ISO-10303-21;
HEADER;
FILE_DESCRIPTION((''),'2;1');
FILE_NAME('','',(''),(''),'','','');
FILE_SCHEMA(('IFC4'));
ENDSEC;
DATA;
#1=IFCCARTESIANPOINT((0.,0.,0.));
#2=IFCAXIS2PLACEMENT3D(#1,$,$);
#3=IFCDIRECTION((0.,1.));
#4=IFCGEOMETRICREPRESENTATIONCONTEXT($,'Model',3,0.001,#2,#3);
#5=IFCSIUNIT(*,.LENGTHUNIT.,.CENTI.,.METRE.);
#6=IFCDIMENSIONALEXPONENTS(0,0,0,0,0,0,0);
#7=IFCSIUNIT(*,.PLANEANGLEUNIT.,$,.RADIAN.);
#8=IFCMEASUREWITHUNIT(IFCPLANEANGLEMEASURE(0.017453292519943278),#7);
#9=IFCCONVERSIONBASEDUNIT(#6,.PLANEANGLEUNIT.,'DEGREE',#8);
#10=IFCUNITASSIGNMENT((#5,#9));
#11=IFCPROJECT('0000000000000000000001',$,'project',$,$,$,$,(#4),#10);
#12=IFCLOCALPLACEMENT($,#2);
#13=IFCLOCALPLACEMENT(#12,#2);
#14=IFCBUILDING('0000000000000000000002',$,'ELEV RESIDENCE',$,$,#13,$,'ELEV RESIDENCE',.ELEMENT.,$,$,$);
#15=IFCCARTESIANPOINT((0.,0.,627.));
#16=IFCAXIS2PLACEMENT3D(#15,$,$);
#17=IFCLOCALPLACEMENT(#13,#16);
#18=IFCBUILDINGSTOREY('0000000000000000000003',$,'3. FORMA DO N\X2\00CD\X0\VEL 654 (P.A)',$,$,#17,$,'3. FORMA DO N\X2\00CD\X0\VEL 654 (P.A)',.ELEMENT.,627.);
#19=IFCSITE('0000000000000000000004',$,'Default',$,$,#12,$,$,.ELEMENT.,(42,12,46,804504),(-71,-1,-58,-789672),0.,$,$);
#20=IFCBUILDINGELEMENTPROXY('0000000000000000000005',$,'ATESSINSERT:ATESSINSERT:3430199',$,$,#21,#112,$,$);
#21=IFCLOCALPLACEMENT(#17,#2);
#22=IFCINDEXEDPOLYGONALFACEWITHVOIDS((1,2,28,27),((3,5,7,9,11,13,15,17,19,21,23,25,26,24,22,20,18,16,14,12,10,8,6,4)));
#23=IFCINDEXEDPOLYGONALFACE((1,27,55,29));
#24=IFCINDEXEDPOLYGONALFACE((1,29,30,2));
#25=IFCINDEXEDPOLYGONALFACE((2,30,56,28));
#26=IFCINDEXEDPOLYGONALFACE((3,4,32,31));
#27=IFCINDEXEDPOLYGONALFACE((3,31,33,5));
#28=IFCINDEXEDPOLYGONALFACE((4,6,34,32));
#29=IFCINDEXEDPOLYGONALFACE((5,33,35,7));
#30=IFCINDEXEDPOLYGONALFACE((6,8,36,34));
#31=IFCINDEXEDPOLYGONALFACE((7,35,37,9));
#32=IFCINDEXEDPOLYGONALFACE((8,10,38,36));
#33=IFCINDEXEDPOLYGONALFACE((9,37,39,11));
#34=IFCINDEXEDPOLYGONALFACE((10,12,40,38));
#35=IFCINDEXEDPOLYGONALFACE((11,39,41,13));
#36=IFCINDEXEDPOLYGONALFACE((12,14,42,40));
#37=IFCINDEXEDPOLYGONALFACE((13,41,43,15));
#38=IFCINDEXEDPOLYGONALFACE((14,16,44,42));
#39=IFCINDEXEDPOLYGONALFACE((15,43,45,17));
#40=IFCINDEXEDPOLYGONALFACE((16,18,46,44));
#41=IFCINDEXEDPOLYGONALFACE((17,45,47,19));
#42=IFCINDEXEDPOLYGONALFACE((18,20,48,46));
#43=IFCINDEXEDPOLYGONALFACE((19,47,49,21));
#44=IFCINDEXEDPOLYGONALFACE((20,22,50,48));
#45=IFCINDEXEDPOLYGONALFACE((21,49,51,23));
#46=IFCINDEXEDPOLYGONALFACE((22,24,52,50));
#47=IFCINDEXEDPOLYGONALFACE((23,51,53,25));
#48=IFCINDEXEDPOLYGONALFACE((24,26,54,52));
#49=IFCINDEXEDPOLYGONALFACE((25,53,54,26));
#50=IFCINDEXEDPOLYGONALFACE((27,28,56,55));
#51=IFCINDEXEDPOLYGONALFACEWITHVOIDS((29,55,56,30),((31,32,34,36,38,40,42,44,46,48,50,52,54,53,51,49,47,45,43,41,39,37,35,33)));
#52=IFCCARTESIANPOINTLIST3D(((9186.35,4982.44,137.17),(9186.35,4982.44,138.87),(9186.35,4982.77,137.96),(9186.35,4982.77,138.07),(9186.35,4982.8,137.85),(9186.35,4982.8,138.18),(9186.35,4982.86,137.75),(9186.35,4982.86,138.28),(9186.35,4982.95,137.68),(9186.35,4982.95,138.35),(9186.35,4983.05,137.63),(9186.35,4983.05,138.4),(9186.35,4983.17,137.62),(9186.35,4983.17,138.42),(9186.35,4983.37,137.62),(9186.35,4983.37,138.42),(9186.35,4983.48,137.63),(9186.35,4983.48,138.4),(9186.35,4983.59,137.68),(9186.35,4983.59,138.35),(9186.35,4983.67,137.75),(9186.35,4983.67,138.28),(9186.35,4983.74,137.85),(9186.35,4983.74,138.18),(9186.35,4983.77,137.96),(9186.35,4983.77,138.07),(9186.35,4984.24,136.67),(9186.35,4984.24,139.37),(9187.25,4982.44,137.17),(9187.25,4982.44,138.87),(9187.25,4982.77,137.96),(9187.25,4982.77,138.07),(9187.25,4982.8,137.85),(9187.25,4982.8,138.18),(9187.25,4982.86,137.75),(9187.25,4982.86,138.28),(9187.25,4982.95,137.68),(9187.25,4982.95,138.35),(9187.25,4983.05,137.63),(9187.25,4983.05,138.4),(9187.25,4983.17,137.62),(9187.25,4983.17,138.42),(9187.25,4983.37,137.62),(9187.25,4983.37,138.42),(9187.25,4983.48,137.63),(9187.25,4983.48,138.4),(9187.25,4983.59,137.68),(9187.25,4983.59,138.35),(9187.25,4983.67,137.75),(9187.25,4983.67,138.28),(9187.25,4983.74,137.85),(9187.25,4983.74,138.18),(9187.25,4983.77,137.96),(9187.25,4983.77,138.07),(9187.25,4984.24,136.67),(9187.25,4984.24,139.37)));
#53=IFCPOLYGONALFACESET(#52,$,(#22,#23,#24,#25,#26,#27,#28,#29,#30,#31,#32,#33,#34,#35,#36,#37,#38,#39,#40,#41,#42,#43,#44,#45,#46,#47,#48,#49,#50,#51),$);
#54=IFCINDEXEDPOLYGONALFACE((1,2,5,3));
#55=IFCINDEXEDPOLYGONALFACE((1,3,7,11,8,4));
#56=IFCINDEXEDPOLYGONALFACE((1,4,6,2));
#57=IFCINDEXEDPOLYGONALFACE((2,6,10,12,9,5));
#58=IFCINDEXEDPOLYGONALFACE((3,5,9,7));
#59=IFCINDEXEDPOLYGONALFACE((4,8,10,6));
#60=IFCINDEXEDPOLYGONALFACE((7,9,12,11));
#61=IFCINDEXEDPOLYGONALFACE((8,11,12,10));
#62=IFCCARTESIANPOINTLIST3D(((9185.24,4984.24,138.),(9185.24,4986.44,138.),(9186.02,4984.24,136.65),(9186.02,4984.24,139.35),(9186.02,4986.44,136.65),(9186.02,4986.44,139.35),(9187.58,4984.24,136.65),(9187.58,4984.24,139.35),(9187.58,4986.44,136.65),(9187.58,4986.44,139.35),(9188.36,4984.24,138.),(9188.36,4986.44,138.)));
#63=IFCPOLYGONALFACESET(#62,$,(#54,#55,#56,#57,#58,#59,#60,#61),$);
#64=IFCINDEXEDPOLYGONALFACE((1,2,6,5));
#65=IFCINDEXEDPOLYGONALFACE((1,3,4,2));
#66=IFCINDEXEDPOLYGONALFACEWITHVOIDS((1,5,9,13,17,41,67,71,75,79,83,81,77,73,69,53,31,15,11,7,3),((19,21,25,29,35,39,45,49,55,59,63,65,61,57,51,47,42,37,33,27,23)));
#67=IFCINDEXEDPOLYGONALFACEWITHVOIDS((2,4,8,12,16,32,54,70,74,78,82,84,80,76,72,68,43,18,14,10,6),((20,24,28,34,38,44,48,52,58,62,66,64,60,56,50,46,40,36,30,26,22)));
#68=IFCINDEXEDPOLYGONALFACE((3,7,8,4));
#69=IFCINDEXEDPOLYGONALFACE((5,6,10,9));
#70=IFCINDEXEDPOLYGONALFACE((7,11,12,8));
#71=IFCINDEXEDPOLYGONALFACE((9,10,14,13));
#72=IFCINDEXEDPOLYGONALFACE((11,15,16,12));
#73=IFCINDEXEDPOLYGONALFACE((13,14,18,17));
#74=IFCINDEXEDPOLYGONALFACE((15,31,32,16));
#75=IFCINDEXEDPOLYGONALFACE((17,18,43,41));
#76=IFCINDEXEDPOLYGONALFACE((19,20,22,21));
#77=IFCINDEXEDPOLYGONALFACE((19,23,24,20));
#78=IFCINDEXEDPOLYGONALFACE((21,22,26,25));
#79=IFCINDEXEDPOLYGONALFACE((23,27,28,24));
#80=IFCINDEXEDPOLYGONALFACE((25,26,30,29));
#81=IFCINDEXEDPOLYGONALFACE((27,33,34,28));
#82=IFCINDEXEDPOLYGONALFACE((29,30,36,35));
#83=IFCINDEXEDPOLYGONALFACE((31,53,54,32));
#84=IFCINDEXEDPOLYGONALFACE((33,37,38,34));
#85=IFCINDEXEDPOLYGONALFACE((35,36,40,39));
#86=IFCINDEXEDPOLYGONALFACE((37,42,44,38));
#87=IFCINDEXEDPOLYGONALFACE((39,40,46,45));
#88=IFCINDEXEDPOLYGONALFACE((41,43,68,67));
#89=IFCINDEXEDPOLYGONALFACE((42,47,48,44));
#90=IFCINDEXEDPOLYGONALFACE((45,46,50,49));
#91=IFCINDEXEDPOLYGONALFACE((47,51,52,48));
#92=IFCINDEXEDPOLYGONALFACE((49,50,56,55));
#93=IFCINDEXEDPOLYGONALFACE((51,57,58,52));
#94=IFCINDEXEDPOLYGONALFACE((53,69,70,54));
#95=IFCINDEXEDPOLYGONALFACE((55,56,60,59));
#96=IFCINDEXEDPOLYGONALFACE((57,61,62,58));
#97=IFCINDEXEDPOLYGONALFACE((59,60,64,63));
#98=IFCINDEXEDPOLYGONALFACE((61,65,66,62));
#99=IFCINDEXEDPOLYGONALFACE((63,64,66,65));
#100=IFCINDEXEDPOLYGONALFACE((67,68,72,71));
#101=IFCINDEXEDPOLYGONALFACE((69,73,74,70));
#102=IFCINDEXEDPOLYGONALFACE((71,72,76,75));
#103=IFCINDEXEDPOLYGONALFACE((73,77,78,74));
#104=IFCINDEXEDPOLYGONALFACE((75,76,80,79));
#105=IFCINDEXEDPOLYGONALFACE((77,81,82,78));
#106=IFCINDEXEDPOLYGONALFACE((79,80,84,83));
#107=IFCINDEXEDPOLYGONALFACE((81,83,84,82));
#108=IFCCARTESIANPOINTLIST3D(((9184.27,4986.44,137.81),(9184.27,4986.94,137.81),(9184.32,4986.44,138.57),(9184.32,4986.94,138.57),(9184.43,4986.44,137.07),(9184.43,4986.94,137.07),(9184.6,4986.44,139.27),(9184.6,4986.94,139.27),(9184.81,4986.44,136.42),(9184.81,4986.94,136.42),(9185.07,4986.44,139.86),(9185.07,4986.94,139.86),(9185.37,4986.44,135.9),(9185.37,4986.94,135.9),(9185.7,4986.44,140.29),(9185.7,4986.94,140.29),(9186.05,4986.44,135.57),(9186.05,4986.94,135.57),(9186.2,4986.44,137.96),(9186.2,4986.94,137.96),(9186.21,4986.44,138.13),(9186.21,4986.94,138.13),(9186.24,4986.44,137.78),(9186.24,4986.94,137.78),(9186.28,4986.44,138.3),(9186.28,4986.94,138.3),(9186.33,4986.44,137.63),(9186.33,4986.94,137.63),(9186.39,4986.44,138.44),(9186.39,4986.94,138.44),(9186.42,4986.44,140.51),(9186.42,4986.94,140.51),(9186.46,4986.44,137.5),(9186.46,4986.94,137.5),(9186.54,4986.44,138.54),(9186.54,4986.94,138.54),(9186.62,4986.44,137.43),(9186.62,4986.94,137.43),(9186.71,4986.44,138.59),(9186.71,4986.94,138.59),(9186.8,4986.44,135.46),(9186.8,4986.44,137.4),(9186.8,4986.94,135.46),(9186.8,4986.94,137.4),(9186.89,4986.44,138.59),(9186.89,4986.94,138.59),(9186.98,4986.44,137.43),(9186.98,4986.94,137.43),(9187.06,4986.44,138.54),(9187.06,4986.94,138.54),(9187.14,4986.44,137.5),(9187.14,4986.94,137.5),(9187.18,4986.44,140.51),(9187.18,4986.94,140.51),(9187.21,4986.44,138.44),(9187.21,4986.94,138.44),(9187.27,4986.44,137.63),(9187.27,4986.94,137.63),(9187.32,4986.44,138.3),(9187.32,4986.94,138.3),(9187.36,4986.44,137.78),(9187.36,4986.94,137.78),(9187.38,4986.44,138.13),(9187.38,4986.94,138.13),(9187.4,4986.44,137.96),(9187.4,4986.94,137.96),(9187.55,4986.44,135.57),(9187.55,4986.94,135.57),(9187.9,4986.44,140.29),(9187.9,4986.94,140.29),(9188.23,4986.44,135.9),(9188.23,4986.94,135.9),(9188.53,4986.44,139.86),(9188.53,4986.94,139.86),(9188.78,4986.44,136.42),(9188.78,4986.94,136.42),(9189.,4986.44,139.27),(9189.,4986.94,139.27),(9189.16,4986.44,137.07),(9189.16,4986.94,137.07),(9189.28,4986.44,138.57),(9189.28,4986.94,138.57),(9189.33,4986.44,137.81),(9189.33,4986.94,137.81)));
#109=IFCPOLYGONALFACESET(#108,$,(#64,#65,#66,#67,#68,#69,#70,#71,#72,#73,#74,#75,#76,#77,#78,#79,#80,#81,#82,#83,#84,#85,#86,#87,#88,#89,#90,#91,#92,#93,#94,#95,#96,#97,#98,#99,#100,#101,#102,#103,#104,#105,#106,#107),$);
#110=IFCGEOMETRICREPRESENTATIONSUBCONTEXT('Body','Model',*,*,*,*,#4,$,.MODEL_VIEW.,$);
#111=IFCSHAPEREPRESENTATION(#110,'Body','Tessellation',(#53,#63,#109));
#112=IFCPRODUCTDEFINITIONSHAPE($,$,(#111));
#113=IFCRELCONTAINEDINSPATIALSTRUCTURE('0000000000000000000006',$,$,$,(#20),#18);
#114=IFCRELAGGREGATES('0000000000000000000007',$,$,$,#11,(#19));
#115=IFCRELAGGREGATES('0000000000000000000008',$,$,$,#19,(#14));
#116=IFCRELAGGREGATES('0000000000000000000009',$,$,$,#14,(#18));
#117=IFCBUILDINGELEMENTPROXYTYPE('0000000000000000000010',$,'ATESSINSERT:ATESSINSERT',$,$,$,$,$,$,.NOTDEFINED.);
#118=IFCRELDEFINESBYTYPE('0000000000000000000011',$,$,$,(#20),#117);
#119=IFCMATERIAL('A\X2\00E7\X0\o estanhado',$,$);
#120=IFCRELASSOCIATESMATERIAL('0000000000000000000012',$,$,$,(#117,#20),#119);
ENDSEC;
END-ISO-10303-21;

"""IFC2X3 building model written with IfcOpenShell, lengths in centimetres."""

from ifc_helpers import new_model, entity, si_unit, converted_unit, direction, frame, frame_2d, origin, place, context, subcontext, project, spatial, polyline, circle_curve, parameter, trimmed, segment, composite_curve, hollow_circle, outline, extrude, source, transform, mapped, material, type_object, type_shapes, element, save


model = new_model("IFC2X3")

# Units and contexts
model_context = context("Model", 3, precision=0.001, world=origin(), true_north=direction((0.0, 1.0)))
body_context = subcontext(model_context, "Body", "Model", "MODEL_VIEW")
ifc_project = project(units=[si_unit("LENGTHUNIT", "METRE", prefix="CENTI"), converted_unit("PLANEANGLEUNIT", "DEGREE", entity("IfcPlaneAngleMeasure", 0.017453292519943278), si_unit("PLANEANGLEUNIT", "RADIAN"), dimensions=[0, 0, 0, 0, 0, 0, 0])], contexts=[model_context])

# Site, building, storey
site_placement = place(None, origin())
site = spatial("IfcSite", under=ifc_project, at=site_placement, Name="Default", CompositionType="ELEMENT", RefLatitude=(42, 12, 46, 804504), RefLongitude=(-71, -1, -58, -789672), RefElevation=0.0)
building_placement = place(site_placement, origin())
building = spatial("IfcBuilding", under=site, at=building_placement, Name="ELEV RESIDENCE", LongName="ELEV RESIDENCE", CompositionType="ELEMENT")
storey_placement = place(building_placement, frame((0.0, 0.0, 627.0)))
storey = spatial("IfcBuildingStorey", under=building, at=storey_placement, Name="3. FORMA DO NÍVEL 654 (P.A)", LongName="3. FORMA DO NÍVEL 654 (P.A)", CompositionType="ELEMENT", Elevation=627.0)

# Building element proxy
ifc_material_1 = material(Name="Aço estanhado")
building_element_proxy_type_1 = type_object("IfcBuildingElementProxyType", Name="ATESSINSERT:ATESSINSERT", PredefinedType="NOTDEFINED", material=ifc_material_1)
shared_shape_1 = source(origin(), body_context, "Body", "SweptSolid", [
    extrude(outline(polyline([(-1.35, -0.9), (1.35, -0.9), (0.85, 0.9), (-0.85, 0.9), (-1.35, -0.9)]), holes=[composite_curve([segment(trimmed(circle_curve(frame_2d((0.0, 0.17), x_axis=(1.0, 0.0)), 0.4), [parameter(0.0)], [parameter(180.0)], True, "PARAMETER"), False, "CONTINUOUS"), segment(polyline([(0.4, 0.17), (0.4, -0.03)]), True, "CONTINUOUS"), segment(trimmed(circle_curve(frame_2d((0.0, -0.03), x_axis=(1.0, 0.0)), 0.4), [parameter(180.0)], [parameter(0.0)], True, "PARAMETER"), False, "CONTINUOUS"), segment(polyline([(-0.4, -0.03), (-0.4, 0.17)]), True, "CONTINUOUS")], self_intersect=False)]), frame((-1.4, -0.45, 30.02), z_axis=(0.0, 1.0, 0.0), x_axis=(0.0, 0.0, 1.0)), (0.0, 0.0, 1.0), 0.9),
    extrude(outline(polyline([(-0.78, -1.35), (0.78, -1.35), (1.56, 0.0), (0.78, 1.35), (-0.78, 1.35), (-1.56, 0.0), (-0.78, -1.35)])), frame((-4.5, 0.0, 30.0), z_axis=(1.0, 0.0, 0.0), x_axis=(0.0, 1.0, 0.0)), (0.0, 0.0, 1.0), 2.2),
    extrude(hollow_circle(Radius=2.54, WallThickness=1.94, at=frame_2d((0.0, 0.0), x_axis=(1.0, 0.0))), frame((-5.0, 0.0, 30.0), z_axis=(1.0, 0.0, 0.0), x_axis=(0.0, 0.0, -1.0)), (0.0, 0.0, 1.0), 0.5),
])
type_shapes(building_element_proxy_type_1, [shared_shape_1])
proxy_placement = place(storey_placement, frame((9186.8, 4981.94, 108.0), z_axis=(0.0, 0.0, 1.0), x_axis=(0.0, -1.0, 0.0)))
element("IfcBuildingElementProxy", 1, at=proxy_placement, inside=storey, type_object=building_element_proxy_type_1, material=ifc_material_1, Name="ATESSINSERT:ATESSINSERT:3430199", context=body_context, shape_type="MappedRepresentation", body=[
    mapped(shared_shape_1, transform((0.0, 0.0, 0.0), scale=1.0)),
])

save(model, "model.ifc")
